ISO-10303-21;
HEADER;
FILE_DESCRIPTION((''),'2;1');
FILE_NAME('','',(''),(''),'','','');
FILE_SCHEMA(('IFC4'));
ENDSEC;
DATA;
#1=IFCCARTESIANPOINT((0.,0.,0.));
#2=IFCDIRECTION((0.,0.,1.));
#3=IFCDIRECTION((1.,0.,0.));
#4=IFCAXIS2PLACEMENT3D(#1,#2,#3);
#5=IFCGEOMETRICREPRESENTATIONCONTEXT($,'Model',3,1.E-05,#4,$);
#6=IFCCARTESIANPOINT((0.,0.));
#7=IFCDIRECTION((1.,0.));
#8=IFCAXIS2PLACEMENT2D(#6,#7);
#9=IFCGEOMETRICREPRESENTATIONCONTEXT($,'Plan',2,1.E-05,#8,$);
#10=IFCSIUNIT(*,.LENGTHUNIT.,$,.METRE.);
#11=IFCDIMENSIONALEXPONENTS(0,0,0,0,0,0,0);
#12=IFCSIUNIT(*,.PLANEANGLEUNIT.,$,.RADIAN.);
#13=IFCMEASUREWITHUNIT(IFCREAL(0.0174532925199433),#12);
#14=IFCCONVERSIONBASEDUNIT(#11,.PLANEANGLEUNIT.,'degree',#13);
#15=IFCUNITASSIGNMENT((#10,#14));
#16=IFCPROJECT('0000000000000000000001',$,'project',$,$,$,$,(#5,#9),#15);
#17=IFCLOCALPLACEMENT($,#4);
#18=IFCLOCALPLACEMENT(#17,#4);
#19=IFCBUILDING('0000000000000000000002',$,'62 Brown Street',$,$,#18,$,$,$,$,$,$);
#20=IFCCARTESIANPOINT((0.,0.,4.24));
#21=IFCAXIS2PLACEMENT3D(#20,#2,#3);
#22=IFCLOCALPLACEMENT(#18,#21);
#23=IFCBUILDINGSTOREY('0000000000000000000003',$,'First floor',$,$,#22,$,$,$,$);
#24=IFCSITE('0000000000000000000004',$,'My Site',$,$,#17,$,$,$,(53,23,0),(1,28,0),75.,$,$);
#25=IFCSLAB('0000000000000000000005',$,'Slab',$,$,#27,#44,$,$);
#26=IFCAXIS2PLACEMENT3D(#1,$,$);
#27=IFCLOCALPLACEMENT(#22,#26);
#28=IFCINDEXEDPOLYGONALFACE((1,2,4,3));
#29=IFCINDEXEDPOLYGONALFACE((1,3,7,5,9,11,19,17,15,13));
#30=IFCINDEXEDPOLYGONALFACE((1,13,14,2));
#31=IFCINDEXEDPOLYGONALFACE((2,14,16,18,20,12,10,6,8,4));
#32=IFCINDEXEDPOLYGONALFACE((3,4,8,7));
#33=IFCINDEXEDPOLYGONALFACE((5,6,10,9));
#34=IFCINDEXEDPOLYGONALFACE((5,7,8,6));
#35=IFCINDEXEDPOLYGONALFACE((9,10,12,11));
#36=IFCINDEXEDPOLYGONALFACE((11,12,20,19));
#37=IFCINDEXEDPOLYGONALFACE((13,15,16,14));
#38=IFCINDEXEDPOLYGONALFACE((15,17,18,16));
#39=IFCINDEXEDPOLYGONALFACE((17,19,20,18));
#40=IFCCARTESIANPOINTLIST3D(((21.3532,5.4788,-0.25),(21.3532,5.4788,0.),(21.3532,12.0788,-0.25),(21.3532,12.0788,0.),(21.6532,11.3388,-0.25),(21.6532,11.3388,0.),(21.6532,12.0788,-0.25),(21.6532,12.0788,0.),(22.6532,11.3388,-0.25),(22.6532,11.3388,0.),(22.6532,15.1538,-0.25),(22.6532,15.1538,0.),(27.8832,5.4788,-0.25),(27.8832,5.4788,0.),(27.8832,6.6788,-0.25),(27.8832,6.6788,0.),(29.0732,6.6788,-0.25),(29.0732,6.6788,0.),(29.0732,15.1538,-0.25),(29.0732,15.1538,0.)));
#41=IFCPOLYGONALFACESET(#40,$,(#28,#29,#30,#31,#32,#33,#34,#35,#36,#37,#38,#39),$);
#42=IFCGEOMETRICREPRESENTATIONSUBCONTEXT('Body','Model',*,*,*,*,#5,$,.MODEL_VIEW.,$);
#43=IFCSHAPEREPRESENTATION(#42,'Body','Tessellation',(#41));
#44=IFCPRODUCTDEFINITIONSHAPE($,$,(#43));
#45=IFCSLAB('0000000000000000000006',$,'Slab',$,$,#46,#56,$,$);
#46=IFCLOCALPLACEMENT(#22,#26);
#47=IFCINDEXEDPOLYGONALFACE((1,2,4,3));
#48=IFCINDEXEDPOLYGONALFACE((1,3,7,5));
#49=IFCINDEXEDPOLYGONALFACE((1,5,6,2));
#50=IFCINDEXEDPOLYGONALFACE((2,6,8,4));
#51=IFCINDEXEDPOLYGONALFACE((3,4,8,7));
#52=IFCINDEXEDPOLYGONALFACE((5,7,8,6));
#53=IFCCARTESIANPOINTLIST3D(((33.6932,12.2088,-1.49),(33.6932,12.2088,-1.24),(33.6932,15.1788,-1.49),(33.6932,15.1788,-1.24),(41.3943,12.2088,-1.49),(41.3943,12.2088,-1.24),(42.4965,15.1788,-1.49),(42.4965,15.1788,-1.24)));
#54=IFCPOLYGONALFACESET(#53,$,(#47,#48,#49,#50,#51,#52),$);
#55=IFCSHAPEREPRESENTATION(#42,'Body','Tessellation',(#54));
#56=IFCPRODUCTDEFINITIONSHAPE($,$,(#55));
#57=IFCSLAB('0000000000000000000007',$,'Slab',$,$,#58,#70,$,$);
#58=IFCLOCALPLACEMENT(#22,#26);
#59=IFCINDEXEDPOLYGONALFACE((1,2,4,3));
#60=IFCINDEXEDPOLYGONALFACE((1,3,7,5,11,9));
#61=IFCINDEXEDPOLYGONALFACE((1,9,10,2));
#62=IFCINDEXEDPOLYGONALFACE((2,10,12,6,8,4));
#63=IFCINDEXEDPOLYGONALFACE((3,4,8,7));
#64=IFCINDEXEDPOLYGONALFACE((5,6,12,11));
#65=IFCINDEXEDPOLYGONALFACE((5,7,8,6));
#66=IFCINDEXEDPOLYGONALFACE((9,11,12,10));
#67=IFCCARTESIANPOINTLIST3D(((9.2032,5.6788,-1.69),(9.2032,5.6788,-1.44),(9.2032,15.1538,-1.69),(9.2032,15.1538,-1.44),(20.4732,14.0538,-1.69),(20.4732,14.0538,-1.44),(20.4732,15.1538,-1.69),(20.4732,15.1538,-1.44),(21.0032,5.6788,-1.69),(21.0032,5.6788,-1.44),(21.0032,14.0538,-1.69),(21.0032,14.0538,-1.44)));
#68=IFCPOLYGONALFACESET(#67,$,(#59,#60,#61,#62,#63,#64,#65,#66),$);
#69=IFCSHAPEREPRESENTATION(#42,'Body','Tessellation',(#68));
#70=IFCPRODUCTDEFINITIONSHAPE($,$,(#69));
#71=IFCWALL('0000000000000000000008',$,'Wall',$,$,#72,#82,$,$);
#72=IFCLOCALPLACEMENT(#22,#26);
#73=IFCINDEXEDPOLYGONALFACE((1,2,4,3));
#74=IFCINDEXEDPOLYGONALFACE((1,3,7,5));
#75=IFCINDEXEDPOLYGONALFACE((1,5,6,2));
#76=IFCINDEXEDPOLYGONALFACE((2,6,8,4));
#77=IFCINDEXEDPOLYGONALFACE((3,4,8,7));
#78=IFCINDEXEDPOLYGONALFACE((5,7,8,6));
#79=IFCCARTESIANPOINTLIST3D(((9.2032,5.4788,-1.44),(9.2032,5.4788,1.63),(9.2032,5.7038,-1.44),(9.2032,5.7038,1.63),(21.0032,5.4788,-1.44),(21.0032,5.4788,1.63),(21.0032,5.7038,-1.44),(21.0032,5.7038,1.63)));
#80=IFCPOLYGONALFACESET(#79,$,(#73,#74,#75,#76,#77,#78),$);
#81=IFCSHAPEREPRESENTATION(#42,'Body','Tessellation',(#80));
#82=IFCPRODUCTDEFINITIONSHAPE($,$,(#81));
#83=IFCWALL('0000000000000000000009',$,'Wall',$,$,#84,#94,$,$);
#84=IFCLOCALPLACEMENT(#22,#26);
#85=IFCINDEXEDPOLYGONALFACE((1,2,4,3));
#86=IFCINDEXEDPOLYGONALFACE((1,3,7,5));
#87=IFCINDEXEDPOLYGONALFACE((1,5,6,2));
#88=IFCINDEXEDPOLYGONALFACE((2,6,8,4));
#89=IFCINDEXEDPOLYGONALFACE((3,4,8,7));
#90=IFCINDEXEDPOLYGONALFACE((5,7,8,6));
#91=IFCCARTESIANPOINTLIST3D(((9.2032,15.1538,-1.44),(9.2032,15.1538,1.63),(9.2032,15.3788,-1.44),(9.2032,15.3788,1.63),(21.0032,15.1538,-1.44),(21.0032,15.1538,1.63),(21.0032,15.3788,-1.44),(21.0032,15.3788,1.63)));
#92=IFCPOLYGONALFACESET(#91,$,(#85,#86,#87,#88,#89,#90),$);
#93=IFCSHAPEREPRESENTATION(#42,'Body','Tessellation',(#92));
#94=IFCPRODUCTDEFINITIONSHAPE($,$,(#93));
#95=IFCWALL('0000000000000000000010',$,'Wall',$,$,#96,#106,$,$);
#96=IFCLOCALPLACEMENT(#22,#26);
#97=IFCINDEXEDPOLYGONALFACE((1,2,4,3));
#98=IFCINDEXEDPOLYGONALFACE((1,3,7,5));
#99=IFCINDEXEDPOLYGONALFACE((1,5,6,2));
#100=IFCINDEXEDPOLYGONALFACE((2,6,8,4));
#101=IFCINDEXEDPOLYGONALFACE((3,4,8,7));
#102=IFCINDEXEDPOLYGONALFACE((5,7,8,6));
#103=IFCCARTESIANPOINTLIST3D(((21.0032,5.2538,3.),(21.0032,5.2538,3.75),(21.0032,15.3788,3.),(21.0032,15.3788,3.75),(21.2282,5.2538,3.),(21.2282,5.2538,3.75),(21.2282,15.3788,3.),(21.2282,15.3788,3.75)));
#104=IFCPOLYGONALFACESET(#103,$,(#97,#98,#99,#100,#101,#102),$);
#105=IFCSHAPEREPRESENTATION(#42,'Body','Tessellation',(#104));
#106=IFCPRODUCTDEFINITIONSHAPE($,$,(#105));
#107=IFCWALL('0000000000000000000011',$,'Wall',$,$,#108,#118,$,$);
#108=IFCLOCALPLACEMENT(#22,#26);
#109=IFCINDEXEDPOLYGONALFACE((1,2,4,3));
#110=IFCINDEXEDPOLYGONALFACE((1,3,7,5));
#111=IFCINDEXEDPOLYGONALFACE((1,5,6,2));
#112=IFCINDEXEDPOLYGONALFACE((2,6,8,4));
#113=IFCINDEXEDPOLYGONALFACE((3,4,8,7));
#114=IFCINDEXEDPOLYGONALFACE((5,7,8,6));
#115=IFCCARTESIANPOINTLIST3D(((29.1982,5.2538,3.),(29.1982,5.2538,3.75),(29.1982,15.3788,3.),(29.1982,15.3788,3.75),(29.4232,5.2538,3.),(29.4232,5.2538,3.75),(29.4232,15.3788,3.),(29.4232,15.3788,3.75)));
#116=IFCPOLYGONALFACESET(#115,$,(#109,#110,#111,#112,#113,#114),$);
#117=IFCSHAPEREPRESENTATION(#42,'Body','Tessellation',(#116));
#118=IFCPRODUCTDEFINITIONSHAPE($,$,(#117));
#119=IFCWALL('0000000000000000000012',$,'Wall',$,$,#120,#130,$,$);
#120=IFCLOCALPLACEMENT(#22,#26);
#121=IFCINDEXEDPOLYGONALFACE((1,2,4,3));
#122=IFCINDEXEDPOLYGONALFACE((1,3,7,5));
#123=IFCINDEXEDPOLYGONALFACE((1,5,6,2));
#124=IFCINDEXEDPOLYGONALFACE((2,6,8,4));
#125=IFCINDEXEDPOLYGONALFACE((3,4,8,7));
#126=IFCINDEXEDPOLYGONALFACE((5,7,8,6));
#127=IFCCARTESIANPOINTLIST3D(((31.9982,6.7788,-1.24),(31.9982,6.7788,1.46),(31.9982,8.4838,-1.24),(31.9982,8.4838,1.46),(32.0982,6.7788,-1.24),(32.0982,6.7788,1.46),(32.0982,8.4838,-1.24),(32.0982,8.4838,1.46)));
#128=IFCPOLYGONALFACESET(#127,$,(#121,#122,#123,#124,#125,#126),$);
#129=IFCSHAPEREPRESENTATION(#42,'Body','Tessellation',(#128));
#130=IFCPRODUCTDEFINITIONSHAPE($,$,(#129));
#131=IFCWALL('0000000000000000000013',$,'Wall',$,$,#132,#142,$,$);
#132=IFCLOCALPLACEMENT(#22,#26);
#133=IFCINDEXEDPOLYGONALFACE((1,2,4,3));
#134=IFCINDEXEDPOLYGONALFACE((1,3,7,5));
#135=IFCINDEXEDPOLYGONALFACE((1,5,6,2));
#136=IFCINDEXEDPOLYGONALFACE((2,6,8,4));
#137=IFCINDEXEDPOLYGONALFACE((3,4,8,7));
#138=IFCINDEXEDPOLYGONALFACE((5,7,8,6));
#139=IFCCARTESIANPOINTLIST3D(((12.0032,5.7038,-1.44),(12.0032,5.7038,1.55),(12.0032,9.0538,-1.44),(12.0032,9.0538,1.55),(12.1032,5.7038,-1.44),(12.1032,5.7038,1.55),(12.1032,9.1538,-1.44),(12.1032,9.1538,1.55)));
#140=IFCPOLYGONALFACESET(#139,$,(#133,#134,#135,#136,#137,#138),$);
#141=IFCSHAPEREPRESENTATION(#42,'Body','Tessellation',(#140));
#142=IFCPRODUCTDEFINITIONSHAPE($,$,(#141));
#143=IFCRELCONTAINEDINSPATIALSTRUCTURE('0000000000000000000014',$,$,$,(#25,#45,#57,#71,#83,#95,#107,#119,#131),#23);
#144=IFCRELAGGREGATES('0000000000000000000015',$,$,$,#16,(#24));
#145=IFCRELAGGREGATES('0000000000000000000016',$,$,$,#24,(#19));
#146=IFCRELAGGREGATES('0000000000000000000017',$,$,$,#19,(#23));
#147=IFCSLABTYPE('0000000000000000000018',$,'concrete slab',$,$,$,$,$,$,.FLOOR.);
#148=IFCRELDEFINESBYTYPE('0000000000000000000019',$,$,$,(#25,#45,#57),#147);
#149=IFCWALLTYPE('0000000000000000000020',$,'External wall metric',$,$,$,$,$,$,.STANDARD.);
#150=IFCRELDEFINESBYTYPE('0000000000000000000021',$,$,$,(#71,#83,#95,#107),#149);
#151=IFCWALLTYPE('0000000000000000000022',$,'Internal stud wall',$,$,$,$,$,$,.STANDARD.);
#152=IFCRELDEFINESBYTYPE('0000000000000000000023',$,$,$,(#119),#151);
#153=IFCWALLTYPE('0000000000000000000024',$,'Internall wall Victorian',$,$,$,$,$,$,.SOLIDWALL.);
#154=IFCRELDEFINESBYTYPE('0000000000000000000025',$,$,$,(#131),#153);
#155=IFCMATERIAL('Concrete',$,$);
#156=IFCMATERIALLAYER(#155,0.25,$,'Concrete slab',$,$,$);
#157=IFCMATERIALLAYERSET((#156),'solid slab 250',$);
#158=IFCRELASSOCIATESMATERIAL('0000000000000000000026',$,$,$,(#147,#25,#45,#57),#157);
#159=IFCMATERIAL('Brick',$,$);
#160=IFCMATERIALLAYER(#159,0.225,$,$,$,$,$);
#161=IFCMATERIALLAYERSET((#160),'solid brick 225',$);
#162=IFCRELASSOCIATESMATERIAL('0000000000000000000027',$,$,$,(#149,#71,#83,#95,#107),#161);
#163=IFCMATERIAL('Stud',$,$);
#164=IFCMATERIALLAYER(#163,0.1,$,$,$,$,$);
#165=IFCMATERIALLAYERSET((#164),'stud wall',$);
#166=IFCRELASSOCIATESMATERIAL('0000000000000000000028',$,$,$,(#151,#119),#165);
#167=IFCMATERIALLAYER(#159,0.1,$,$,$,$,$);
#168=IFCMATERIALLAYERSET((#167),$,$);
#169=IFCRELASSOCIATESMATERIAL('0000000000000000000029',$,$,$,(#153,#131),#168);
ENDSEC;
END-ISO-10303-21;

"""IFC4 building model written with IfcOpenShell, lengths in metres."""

from ifc_helpers import new_model, entity, si_unit, converted_unit, frame, origin_with_axes, origin_2d_with_axis, place, context, subcontext, project, spatial, line, indexed_curve, outline, extrude, clip, halfspace, material, layer, layer_set, layer_usage, type_object, element, save


model = new_model("IFC4")

# Units and contexts
model_context = context("Model", 3, precision=1e-05, world=origin_with_axes())
plan_context = context("Plan", 2, precision=1e-05, world=origin_2d_with_axis())
body_context_1 = subcontext(model_context, "Body", "Model", "MODEL_VIEW")
ifc_project = project(units=[si_unit("LENGTHUNIT", "METRE"), converted_unit("PLANEANGLEUNIT", "degree", entity("IfcReal", 0.0174532925199433), si_unit("PLANEANGLEUNIT", "RADIAN"), dimensions=[0, 0, 0, 0, 0, 0, 0])], contexts=[model_context, plan_context])

# Site, building, storey
site_placement = place(None, origin_with_axes())
site = spatial("IfcSite", under=ifc_project, at=site_placement, Name="My Site", RefLatitude=(53, 23, 0), RefLongitude=(1, 28, 0), RefElevation=75.0)
building_placement = place(site_placement, origin_with_axes())
building = spatial("IfcBuilding", under=site, at=building_placement, Name="62 Brown Street")
storey_placement = place(building_placement, frame((0.0, 0.0, 4.24), z_axis=(0.0, 0.0, 1.0), x_axis=(1.0, 0.0, 0.0)))
storey = spatial("IfcBuildingStorey", under=building, at=storey_placement, Name="First floor")

# Shared definitions
ifc_material_1 = material(Name="Concrete")

# Slabs
ifc_layer_1 = layer(ifc_material_1, 0.25, Name="Concrete slab")
ifc_layer_set_1 = layer_set([ifc_layer_1], Name="solid slab 250")
ifc_layer_usage_1 = layer_usage(ifc_layer_set_1, "AXIS3", "POSITIVE", 0.0)
slab_type = type_object("IfcSlabType", Name="concrete slab", PredefinedType="FLOOR", material=ifc_layer_set_1)
slab_1_placement = place(storey_placement, frame((21.3532, 5.4788, -0.25), z_axis=(0.0, 0.0, 1.0), x_axis=(1.0, 0.0, 0.0)))
element("IfcSlab", 1, at=slab_1_placement, inside=storey, type_object=slab_type, material=ifc_layer_usage_1, Name="Slab", context=body_context_1, shape_type="SweptSolid", body=[
    extrude(outline(indexed_curve([(6.53, 1.2), (6.53, 0.0), (0.0, 0.0), (0.0, 6.6), (0.3, 6.6), (0.3, 5.86), (1.3, 5.86), (1.3, 9.675), (7.72, 9.675), (7.72, 1.2), (6.53, 1.2)])), None, (0.0, 0.0, 1.0), 0.25),
])
ifc_layer_usage_2 = layer_usage(ifc_layer_set_1, "AXIS3", "POSITIVE", 0.0)
slab_2_placement = place(storey_placement, frame((33.6932, 12.2088, -1.49), z_axis=(0.0, 0.0, 1.0), x_axis=(1.0, 0.0, 0.0)))
element("IfcSlab", 2, at=slab_2_placement, inside=storey, type_object=slab_type, material=ifc_layer_usage_2, Name="Slab", context=body_context_1, shape_type="SweptSolid", body=[
    extrude(outline(indexed_curve([(8.8033, 2.97), (7.7011, 0.0), (0.0, 0.0), (0.0, 2.97)], segments=[line(4, 1), line(1, 2), line(2, 3), line(3, 4)], self_intersect=False)), None, (0.0, 0.0, 1.0), 0.25),
])
ifc_layer_usage_3 = layer_usage(ifc_layer_set_1, "AXIS3", "POSITIVE", 0.0)
slab_3_placement = place(storey_placement, frame((9.2032, 5.6788, -1.69), z_axis=(0.0, 0.0, 1.0), x_axis=(1.0, 0.0, 0.0)))
element("IfcSlab", 3, at=slab_3_placement, inside=storey, type_object=slab_type, material=ifc_layer_usage_3, Name="Slab", context=body_context_1, shape_type="SweptSolid", body=[
    extrude(outline(indexed_curve([(11.27, 9.475), (11.8, 0.0), (0.0, 0.0), (0.0, 9.475), (11.8, 8.375), (11.27, 8.375)], segments=[line(6, 1), line(1, 4), line(4, 3), line(3, 2), line(2, 5), line(5, 6)], self_intersect=False)), None, (0.0, 0.0, 1.0), 0.25),
])

# Walls
ifc_material_2 = material(Name="Brick")
ifc_layer_2 = layer(ifc_material_2, 0.225)
ifc_layer_set_2 = layer_set([ifc_layer_2], Name="solid brick 225")
ifc_layer_usage_4 = layer_usage(ifc_layer_set_2, "AXIS2", "POSITIVE", 0.0)
wall_type_1 = type_object("IfcWallType", Name="External wall metric", PredefinedType="STANDARD", material=ifc_layer_set_2)
wall_1_placement = place(storey_placement, frame((9.2032, 5.4788, -1.44), z_axis=(0.0, 0.0, 1.0), x_axis=(1.0, 0.0, 0.0)))
element("IfcWall", 4, at=wall_1_placement, inside=storey, type_object=wall_type_1, material=ifc_layer_usage_4, Name="Wall", context=body_context_1, shape_type="SweptSolid", body=[
    extrude(outline(indexed_curve([(0.0, 0.0), (0.0, 0.225), (11.8, 0.225), (11.8, 0.0), (0.0, 0.0)], self_intersect=False)), origin_with_axes(), (0.0, 0.0, 1.0), 3.07),
])
ifc_layer_usage_5 = layer_usage(ifc_layer_set_2, "AXIS2", "POSITIVE", 0.0)
wall_2_placement = place(storey_placement, frame((21.0032, 15.3788, -1.44), z_axis=(0.0, 0.0, 1.0), x_axis=(-1.0, 0.0, 0.0)))
element("IfcWall", 5, at=wall_2_placement, inside=storey, type_object=wall_type_1, material=ifc_layer_usage_5, Name="Wall", context=body_context_1, shape_type="SweptSolid", body=[
    extrude(outline(indexed_curve([(0.0, 0.0), (0.0, 0.225), (11.8, 0.225), (11.8, 0.0), (0.0, 0.0)], self_intersect=False)), origin_with_axes(), (0.0, 0.0, 1.0), 3.07),
])

# Walls
ifc_layer_usage_6 = layer_usage(ifc_layer_set_2, "AXIS2", "POSITIVE", 0.0)
wall_3_placement = place(storey_placement, frame((21.0032, 15.3788, 3.0), z_axis=(0.0, 0.0, 1.0), x_axis=(0.0, -1.0, 0.0)))
element("IfcWall", 6, at=wall_3_placement, inside=storey, type_object=wall_type_1, material=ifc_layer_usage_6, Name="Wall", context=body_context_1, shape_type="SweptSolid", body=[
    extrude(outline(indexed_curve([(0.0, 0.0), (0.0, 0.225), (10.125, 0.225), (10.125, 0.0), (0.0, 0.0)], self_intersect=False)), origin_with_axes(), (0.0, 0.0, 1.0), 0.75),
])
ifc_layer_usage_7 = layer_usage(ifc_layer_set_2, "AXIS2", "POSITIVE", 0.0)
wall_4_placement = place(storey_placement, frame((29.4232, 5.2538, 3.0), z_axis=(0.0, 0.0, 1.0), x_axis=(0.0, 1.0, 0.0)))
element("IfcWall", 7, at=wall_4_placement, inside=storey, type_object=wall_type_1, material=ifc_layer_usage_7, Name="Wall", context=body_context_1, shape_type="SweptSolid", body=[
    extrude(outline(indexed_curve([(0.0, 0.0), (0.0, 0.225), (10.125, 0.225), (10.125, 0.0), (0.0, 0.0)], self_intersect=False)), origin_with_axes(), (0.0, 0.0, 1.0), 0.75),
])
ifc_material_3 = material(Name="Stud")
ifc_layer_3 = layer(ifc_material_3, 0.1)
ifc_layer_set_3 = layer_set([ifc_layer_3], Name="stud wall")
ifc_layer_usage_8 = layer_usage(ifc_layer_set_3, "AXIS2", "POSITIVE", 0.0)
wall_type_2 = type_object("IfcWallType", Name="Internal stud wall", PredefinedType="STANDARD", material=ifc_layer_set_3)
wall_5_placement = place(storey_placement, frame((32.0982, 6.7788, -1.24), z_axis=(0.0, 0.0, 1.0), x_axis=(0.000001, 1.0, 0.0)))
element("IfcWall", 8, at=wall_5_placement, inside=storey, type_object=wall_type_2, material=ifc_layer_usage_8, Name="Wall", context=body_context_1, shape_type="SweptSolid", body=[
    extrude(outline(indexed_curve([(0.0, 0.0), (0.0, 0.1), (1.705, 0.1), (1.705, 0.0), (0.0, 0.0)], self_intersect=False)), origin_with_axes(), (0.0, 0.0, 1.0), 2.7),
])
ifc_layer_4 = layer(ifc_material_2, 0.1)
ifc_layer_set_4 = layer_set([ifc_layer_4])
ifc_layer_usage_9 = layer_usage(ifc_layer_set_4, "AXIS2", "POSITIVE", 0.0)
wall_type_3 = type_object("IfcWallType", Name="Internall wall Victorian", PredefinedType="SOLIDWALL", material=ifc_layer_set_4)
wall_6_placement = place(storey_placement, frame((12.1032, 5.7038, -1.44), z_axis=(0.0, 0.0, 1.0), x_axis=(0.0, 1.0, 0.0)))
element("IfcWall", 9, at=wall_6_placement, inside=storey, type_object=wall_type_3, material=ifc_layer_usage_9, Name="Wall", context=body_context_1, shape_type="Clipping", body=[
    clip(extrude(outline(indexed_curve([(0.0, 0.0), (0.0, 0.1), (3.45, 0.1), (3.45, 0.0), (0.0, 0.0)], self_intersect=False)), origin_with_axes(), (0.0, 0.0, 1.0), 2.99), halfspace(frame((3.45, 0.0, -2.8), z_axis=(0.707107, 0.707107, 0.0), x_axis=(0.707107, -0.707107, 0.0)), False)),
])

save(model, "model.ifc")
